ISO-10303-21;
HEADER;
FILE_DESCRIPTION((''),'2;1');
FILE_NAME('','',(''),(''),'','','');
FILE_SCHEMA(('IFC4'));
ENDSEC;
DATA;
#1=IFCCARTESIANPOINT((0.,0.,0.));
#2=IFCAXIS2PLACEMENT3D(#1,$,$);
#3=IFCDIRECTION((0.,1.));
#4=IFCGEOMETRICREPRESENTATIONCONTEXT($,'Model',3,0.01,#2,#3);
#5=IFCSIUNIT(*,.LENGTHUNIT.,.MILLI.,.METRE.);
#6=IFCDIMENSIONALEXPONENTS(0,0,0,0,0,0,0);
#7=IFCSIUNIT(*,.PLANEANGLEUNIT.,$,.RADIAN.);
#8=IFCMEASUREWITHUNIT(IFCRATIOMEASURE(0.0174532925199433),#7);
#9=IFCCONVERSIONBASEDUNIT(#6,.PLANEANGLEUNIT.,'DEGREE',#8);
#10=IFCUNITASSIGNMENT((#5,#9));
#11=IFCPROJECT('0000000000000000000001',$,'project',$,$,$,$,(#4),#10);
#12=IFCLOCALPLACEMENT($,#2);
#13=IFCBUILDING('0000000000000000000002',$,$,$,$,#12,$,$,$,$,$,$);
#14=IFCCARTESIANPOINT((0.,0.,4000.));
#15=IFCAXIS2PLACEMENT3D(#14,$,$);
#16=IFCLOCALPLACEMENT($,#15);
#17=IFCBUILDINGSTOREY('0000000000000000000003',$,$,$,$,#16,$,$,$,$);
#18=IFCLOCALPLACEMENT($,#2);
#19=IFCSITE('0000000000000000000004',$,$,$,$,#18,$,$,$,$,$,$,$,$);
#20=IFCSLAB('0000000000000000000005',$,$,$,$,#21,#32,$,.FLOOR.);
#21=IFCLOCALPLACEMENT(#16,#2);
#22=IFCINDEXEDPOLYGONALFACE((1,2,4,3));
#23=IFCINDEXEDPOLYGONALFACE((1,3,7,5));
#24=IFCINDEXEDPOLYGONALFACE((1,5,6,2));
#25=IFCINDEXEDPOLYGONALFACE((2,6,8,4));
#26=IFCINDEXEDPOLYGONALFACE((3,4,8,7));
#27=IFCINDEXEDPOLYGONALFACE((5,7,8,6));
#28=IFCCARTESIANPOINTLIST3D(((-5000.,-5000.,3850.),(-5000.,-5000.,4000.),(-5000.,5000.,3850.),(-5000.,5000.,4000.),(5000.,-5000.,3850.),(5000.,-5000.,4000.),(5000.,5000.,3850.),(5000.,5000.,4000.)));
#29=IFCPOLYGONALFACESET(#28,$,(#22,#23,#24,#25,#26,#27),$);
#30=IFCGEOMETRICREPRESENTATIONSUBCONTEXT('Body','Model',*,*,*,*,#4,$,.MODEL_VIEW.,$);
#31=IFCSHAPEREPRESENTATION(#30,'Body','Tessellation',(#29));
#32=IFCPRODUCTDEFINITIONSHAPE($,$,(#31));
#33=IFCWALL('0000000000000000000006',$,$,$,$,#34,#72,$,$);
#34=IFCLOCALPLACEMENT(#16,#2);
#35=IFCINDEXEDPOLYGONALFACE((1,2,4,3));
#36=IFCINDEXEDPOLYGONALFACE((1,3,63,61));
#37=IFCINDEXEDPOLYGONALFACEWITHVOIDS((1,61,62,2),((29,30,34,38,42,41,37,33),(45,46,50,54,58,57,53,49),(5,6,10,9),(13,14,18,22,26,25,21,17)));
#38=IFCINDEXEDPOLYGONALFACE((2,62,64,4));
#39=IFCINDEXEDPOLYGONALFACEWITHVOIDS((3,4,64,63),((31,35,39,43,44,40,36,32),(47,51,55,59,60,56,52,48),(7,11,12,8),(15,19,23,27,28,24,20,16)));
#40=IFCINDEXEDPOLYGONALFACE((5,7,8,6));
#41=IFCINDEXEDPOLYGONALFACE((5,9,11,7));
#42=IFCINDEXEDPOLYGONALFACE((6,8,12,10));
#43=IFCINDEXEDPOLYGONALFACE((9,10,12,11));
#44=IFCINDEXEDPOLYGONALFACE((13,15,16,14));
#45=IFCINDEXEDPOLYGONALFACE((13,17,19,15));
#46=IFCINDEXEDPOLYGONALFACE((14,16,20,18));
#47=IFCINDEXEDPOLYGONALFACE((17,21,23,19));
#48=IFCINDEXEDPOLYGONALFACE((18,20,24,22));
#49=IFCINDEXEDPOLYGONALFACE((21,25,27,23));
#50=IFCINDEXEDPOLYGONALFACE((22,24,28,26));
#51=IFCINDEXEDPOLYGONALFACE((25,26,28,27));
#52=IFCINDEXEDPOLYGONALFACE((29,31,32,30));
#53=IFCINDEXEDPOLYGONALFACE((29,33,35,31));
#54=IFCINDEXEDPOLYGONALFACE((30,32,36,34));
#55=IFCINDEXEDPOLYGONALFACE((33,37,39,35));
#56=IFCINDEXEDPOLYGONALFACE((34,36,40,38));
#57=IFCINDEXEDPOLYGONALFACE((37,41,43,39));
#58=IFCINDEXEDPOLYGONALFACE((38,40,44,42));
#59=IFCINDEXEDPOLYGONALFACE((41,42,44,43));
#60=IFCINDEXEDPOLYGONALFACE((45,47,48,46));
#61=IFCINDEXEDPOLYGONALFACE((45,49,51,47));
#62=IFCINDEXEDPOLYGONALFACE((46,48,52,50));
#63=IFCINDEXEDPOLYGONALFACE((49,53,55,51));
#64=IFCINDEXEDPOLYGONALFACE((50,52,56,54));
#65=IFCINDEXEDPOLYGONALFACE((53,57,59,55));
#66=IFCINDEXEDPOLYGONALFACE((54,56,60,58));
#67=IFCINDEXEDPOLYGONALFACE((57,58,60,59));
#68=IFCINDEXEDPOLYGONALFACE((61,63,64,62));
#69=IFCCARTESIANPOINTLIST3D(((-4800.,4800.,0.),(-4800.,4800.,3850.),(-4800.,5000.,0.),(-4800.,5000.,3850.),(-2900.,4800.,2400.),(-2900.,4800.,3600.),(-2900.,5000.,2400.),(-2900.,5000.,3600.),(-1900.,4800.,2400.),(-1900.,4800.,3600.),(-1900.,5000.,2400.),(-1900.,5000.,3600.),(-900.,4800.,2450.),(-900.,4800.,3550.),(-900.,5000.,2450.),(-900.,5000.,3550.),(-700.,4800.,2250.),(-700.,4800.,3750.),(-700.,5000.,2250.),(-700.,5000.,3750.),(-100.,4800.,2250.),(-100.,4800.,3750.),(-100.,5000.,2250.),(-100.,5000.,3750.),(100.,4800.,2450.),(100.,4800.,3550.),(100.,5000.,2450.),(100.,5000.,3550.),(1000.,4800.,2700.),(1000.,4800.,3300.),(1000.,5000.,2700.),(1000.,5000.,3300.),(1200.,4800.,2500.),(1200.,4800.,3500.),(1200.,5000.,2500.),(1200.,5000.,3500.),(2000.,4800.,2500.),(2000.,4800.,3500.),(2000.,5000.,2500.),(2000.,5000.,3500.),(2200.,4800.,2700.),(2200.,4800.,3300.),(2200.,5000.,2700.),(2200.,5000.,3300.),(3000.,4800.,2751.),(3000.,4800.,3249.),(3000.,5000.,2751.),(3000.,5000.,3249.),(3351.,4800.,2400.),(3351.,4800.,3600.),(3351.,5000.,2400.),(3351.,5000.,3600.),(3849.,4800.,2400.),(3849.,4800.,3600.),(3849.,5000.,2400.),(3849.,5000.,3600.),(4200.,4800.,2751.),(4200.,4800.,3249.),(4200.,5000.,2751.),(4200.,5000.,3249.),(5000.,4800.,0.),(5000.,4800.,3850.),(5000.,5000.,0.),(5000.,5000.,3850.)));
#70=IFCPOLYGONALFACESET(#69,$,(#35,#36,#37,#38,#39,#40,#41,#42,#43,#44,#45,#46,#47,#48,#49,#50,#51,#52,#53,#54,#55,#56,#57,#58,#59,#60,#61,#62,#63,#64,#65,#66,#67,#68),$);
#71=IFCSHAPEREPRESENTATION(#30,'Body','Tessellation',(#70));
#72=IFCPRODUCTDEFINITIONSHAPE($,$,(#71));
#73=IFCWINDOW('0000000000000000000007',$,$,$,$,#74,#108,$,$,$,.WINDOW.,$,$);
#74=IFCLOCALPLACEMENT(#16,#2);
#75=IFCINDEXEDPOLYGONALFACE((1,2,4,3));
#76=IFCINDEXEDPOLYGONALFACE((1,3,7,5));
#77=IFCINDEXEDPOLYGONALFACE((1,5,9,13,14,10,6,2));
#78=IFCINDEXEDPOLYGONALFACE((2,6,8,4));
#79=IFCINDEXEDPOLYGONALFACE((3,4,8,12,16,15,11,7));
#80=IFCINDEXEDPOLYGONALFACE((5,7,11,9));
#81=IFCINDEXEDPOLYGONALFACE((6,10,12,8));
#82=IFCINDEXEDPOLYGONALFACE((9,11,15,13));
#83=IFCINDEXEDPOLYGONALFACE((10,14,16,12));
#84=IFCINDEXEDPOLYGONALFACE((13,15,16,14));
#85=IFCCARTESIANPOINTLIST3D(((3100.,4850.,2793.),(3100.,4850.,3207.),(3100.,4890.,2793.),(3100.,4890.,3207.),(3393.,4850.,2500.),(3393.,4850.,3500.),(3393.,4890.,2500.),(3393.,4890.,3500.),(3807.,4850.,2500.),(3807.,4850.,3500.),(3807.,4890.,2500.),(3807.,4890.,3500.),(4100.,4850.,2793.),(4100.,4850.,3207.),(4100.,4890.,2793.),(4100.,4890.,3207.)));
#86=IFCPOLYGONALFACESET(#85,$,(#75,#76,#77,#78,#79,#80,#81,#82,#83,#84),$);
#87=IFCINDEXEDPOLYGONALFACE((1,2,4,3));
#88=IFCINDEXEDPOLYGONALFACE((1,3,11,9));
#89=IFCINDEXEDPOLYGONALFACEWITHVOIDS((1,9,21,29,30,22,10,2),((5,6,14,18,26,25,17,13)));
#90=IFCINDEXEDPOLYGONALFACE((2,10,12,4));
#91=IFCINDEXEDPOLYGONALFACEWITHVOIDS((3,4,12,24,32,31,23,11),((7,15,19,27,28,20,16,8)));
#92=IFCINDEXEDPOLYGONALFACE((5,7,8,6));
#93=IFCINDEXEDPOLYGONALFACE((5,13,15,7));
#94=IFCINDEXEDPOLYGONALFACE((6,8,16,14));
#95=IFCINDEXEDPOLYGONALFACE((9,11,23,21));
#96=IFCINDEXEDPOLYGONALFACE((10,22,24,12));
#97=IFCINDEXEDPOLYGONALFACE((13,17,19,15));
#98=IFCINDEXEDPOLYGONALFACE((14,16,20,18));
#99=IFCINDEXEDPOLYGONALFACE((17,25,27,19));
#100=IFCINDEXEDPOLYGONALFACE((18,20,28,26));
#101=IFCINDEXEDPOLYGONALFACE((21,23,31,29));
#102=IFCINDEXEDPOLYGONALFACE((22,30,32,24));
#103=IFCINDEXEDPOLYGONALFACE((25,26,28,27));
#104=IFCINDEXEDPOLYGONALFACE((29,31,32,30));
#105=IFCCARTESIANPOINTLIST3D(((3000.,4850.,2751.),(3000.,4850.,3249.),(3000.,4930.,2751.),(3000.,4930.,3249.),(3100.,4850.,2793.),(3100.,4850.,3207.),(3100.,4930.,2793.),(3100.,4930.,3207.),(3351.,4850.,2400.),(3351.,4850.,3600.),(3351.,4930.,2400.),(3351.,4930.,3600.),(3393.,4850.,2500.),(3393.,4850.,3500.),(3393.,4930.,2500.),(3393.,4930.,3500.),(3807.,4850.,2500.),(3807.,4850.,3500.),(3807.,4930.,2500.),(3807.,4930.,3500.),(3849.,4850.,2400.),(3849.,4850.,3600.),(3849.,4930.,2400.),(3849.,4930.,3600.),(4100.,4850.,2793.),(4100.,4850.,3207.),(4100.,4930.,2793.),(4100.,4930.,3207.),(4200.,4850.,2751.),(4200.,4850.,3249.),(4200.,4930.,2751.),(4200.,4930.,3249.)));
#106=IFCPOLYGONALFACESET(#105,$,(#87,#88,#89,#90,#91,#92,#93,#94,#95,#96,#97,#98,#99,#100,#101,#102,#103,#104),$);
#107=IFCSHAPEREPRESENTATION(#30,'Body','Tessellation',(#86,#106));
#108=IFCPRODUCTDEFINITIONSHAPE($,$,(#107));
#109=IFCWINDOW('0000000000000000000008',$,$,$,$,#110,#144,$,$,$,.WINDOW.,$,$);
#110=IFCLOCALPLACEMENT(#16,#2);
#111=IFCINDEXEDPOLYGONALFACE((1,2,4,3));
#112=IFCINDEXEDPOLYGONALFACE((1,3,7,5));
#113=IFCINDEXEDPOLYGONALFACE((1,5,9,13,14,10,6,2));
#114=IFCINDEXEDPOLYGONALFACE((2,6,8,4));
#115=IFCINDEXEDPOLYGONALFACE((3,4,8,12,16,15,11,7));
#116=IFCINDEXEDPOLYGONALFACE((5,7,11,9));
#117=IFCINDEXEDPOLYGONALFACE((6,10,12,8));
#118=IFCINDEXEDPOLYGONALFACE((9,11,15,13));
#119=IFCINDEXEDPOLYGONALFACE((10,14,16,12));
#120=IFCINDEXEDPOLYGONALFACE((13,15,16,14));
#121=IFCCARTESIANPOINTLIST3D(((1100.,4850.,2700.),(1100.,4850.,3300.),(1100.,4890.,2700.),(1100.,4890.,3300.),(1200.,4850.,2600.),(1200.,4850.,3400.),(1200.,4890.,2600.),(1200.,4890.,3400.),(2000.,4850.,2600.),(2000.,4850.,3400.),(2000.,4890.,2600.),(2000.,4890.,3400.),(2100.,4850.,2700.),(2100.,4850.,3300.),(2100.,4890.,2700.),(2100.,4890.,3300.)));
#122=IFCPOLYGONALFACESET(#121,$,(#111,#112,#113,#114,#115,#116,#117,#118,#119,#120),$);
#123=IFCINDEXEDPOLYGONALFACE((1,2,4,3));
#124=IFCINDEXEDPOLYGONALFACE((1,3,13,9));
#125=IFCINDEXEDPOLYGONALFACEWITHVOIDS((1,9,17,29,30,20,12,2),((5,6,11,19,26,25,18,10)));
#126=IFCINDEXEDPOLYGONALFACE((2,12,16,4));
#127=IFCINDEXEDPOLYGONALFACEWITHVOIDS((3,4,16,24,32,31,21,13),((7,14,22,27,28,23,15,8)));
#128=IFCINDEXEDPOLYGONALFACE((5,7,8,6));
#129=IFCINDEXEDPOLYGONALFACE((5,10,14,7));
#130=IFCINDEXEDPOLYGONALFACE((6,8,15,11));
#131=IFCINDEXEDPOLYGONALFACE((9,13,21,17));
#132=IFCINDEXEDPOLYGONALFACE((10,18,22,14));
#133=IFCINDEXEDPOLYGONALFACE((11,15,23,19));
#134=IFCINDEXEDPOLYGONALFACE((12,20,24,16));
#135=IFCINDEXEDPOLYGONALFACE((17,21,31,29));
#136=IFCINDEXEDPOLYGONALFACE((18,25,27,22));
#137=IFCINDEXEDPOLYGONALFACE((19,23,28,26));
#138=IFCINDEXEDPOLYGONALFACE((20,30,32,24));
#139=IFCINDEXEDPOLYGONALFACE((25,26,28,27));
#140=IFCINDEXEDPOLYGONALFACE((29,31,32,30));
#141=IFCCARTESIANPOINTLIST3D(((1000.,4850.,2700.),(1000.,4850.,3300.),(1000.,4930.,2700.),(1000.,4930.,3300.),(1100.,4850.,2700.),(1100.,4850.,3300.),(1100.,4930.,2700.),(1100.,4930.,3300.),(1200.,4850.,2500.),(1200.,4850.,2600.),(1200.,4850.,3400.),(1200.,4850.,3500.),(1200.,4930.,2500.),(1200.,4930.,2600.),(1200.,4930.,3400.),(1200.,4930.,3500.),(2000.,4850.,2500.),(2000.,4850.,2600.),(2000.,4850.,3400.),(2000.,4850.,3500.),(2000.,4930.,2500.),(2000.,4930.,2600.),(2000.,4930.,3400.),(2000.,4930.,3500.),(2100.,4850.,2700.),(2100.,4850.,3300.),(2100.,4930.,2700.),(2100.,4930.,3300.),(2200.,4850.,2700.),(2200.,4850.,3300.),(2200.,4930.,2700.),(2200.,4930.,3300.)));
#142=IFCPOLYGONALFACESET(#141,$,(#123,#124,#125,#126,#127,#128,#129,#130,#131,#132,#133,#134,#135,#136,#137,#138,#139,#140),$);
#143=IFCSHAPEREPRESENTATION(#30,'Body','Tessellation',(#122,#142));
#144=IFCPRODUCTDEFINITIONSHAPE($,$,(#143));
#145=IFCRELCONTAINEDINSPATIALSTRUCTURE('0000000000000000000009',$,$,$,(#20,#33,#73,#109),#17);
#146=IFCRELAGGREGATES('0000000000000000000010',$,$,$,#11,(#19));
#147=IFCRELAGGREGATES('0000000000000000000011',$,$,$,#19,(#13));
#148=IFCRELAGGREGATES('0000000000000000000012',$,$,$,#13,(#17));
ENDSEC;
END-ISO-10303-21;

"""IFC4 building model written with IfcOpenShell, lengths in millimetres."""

from ifc_helpers import new_model, entity, si_unit, converted_unit, direction, frame, origin, origin_2d, place, context, subcontext, project, spatial, polyline, rectangle, outline, extrude, element, save


model = new_model("IFC4")

# Units and contexts
model_context = context("Model", 3, precision=0.01, world=origin(), true_north=direction((0.0, 1.0)))
body_context = subcontext(model_context, "Body", "Model", "MODEL_VIEW")
ifc_project = project(units=[si_unit("LENGTHUNIT", "METRE", prefix="MILLI"), converted_unit("PLANEANGLEUNIT", "DEGREE", entity("IfcRatioMeasure", 0.0174532925199433), si_unit("PLANEANGLEUNIT", "RADIAN"), dimensions=[0, 0, 0, 0, 0, 0, 0])], contexts=[model_context])

# Site, building, storey
site_placement = place(None, origin())
site = spatial("IfcSite", under=ifc_project, at=site_placement)
building_placement = place(None, origin())
building = spatial("IfcBuilding", under=site, at=building_placement)
storey_placement = place(None, frame((0.0, 0.0, 4000.0)))
storey = spatial("IfcBuildingStorey", under=building, at=storey_placement)

# Slab
slab_placement = place(storey_placement, frame((0.0, 0.0, 3850.0)))
element("IfcSlab", 1, at=slab_placement, inside=storey, PredefinedType="FLOOR", context=body_context, shape_type="SweptSolid", body=[
    extrude(rectangle(XDim=10000.0, YDim=10000.0, at=origin_2d()), origin(), (0.0, 0.0, 1.0), 150.0),
])

# Wall, openings
wall_1_placement = place(storey_placement, frame((100.0, 4900.0, 0.0), z_axis=(0.0, 0.0, 1.0), x_axis=(-1.0, 0.0, 0.0)))
wall_1 = element("IfcWall", 2, at=wall_1_placement, inside=storey, context=body_context, shape_type="SweptSolid", body=[
    extrude(rectangle(XDim=9800.0, YDim=200.0, at=origin_2d()), origin(), (0.0, 0.0, 1.0), 3850.0),
])
window_1_placement = place(wall_1_placement, frame((-3500.0, 50.0, 3000.0)))
opening_1_placement = place(window_1_placement, frame((0.0, 50.0, 0.0)))
element("IfcOpeningElement", 3, at=opening_1_placement, cuts=wall_1, context=body_context, shape_type="SweptSolid", body=[
    extrude(outline(polyline([(-600.0, -249.0), (-600.0, 249.0), (-249.0, 600.0), (249.0, 600.0), (600.0, 249.0), (600.0, -249.0), (249.0, -600.0), (-249.0, -600.0), (-600.0, -249.0)])), frame((0.0, 0.0, 0.0), z_axis=(0.0, -1.0, 0.0), x_axis=(1.0, 0.0, 0.0)), (0.0, 0.0, 1.0), 200.0),
])
window_2_placement = place(wall_1_placement, frame((-1500.0, 50.0, 3000.0)))
opening_2_placement = place(window_2_placement, frame((0.0, 50.0, 0.0)))
element("IfcOpeningElement", 4, at=opening_2_placement, cuts=wall_1, context=body_context, shape_type="SweptSolid", body=[
    extrude(outline(polyline([(-600.0, -300.0), (-600.0, 300.0), (-400.0, 500.0), (400.0, 500.0), (600.0, 300.0), (600.0, -300.0), (400.0, -500.0), (-400.0, -500.0), (-600.0, -300.0)])), frame((0.0, 0.0, 0.0), z_axis=(0.0, -1.0, 0.0), x_axis=(1.0, 0.0, 0.0)), (0.0, 0.0, 1.0), 200.0),
])
window_3_placement = place(wall_1_placement, frame((500.0, 50.0, 3000.0)))
opening_3_placement = place(window_3_placement, frame((0.0, 50.0, 0.0)))
element("IfcOpeningElement", 5, at=opening_3_placement, cuts=wall_1, context=body_context, shape_type="SweptSolid", body=[
    extrude(outline(polyline([(-500.0, -550.0), (-500.0, 550.0), (-300.0, 750.0), (300.0, 750.0), (500.0, 550.0), (500.0, -550.0), (300.0, -750.0), (-300.0, -750.0), (-500.0, -550.0)])), frame((0.0, 0.0, 0.0), z_axis=(0.0, -1.0, 0.0), x_axis=(1.0, 0.0, 0.0)), (0.0, 0.0, 1.0), 200.0),
])
window_4_placement = place(wall_1_placement, frame((2500.0, 50.0, 3000.0)))
opening_4_placement = place(window_4_placement, frame((0.0, 50.0, 0.0)))
element("IfcOpeningElement", 6, at=opening_4_placement, cuts=wall_1, context=body_context, shape_type="SweptSolid", body=[
    extrude(outline(polyline([(-500.0, -600.0), (-500.0, 600.0), (-500.0, 600.0), (500.0, 600.0), (500.0, 600.0), (500.0, -600.0), (500.0, -600.0), (-500.0, -600.0), (-500.0, -600.0)])), frame((0.0, 0.0, 0.0), z_axis=(0.0, -1.0, 0.0), x_axis=(1.0, 0.0, 0.0)), (0.0, 0.0, 1.0), 200.0),
])

# Windows
cartesian_point_1 = entity("IfcCartesianPoint", [-500.0, -207.0])
shared_polyline_1 = entity("IfcPolyline", [cartesian_point_1, entity("IfcCartesianPoint", [-500.0, 207.0]), entity("IfcCartesianPoint", [-207.0, 500.0]), entity("IfcCartesianPoint", [207.0, 500.0]), entity("IfcCartesianPoint", [500.0, 207.0]), entity("IfcCartesianPoint", [500.0, -207.0]), entity("IfcCartesianPoint", [207.0, -500.0]), entity("IfcCartesianPoint", [-207.0, -500.0]), cartesian_point_1])
cartesian_point_2 = entity("IfcCartesianPoint", [-600.0, -249.0])
element("IfcWindow", 7, at=window_1_placement, inside=storey, PredefinedType="WINDOW", context=body_context, shape_type="SweptSolid", body=[
    entity("IfcExtrudedAreaSolid", entity("IfcArbitraryClosedProfileDef", "AREA", None, shared_polyline_1), entity("IfcAxis2Placement3D", entity("IfcCartesianPoint", [0.0, 0.0, 0.0]), entity("IfcDirection", [0.0, -1.0, 0.0]), entity("IfcDirection", [1.0, 0.0, 0.0])), entity("IfcDirection", [0.0, 0.0, 1.0]), 40.0),
    entity("IfcExtrudedAreaSolid", entity("IfcArbitraryProfileDefWithVoids", "AREA", None, entity("IfcPolyline", [cartesian_point_2, entity("IfcCartesianPoint", [-600.0, 249.0]), entity("IfcCartesianPoint", [-249.0, 600.0]), entity("IfcCartesianPoint", [249.0, 600.0]), entity("IfcCartesianPoint", [600.0, 249.0]), entity("IfcCartesianPoint", [600.0, -249.0]), entity("IfcCartesianPoint", [249.0, -600.0]), entity("IfcCartesianPoint", [-249.0, -600.0]), cartesian_point_2]), [shared_polyline_1]), entity("IfcAxis2Placement3D", entity("IfcCartesianPoint", [0.0, 0.0, 0.0]), entity("IfcDirection", [0.0, -1.0, 0.0]), entity("IfcDirection", [1.0, 0.0, 0.0])), entity("IfcDirection", [0.0, 0.0, 1.0]), 80.0),
])
cartesian_point_3 = entity("IfcCartesianPoint", [-500.0, -300.0])
shared_polyline_2 = entity("IfcPolyline", [cartesian_point_3, entity("IfcCartesianPoint", [-500.0, 300.0]), entity("IfcCartesianPoint", [-400.0, 400.0]), entity("IfcCartesianPoint", [400.0, 400.0]), entity("IfcCartesianPoint", [500.0, 300.0]), entity("IfcCartesianPoint", [500.0, -300.0]), entity("IfcCartesianPoint", [400.0, -400.0]), entity("IfcCartesianPoint", [-400.0, -400.0]), cartesian_point_3])
cartesian_point_4 = entity("IfcCartesianPoint", [-600.0, -300.0])
element("IfcWindow", 8, at=window_2_placement, inside=storey, PredefinedType="WINDOW", context=body_context, shape_type="SweptSolid", body=[
    entity("IfcExtrudedAreaSolid", entity("IfcArbitraryClosedProfileDef", "AREA", None, shared_polyline_2), entity("IfcAxis2Placement3D", entity("IfcCartesianPoint", [0.0, 0.0, 0.0]), entity("IfcDirection", [0.0, -1.0, 0.0]), entity("IfcDirection", [1.0, 0.0, 0.0])), entity("IfcDirection", [0.0, 0.0, 1.0]), 40.0),
    entity("IfcExtrudedAreaSolid", entity("IfcArbitraryProfileDefWithVoids", "AREA", None, entity("IfcPolyline", [cartesian_point_4, entity("IfcCartesianPoint", [-600.0, 300.0]), entity("IfcCartesianPoint", [-400.0, 500.0]), entity("IfcCartesianPoint", [400.0, 500.0]), entity("IfcCartesianPoint", [600.0, 300.0]), entity("IfcCartesianPoint", [600.0, -300.0]), entity("IfcCartesianPoint", [400.0, -500.0]), entity("IfcCartesianPoint", [-400.0, -500.0]), cartesian_point_4]), [shared_polyline_2]), entity("IfcAxis2Placement3D", entity("IfcCartesianPoint", [0.0, 0.0, 0.0]), entity("IfcDirection", [0.0, -1.0, 0.0]), entity("IfcDirection", [1.0, 0.0, 0.0])), entity("IfcDirection", [0.0, 0.0, 1.0]), 80.0),
])

save(model, "model.ifc")
